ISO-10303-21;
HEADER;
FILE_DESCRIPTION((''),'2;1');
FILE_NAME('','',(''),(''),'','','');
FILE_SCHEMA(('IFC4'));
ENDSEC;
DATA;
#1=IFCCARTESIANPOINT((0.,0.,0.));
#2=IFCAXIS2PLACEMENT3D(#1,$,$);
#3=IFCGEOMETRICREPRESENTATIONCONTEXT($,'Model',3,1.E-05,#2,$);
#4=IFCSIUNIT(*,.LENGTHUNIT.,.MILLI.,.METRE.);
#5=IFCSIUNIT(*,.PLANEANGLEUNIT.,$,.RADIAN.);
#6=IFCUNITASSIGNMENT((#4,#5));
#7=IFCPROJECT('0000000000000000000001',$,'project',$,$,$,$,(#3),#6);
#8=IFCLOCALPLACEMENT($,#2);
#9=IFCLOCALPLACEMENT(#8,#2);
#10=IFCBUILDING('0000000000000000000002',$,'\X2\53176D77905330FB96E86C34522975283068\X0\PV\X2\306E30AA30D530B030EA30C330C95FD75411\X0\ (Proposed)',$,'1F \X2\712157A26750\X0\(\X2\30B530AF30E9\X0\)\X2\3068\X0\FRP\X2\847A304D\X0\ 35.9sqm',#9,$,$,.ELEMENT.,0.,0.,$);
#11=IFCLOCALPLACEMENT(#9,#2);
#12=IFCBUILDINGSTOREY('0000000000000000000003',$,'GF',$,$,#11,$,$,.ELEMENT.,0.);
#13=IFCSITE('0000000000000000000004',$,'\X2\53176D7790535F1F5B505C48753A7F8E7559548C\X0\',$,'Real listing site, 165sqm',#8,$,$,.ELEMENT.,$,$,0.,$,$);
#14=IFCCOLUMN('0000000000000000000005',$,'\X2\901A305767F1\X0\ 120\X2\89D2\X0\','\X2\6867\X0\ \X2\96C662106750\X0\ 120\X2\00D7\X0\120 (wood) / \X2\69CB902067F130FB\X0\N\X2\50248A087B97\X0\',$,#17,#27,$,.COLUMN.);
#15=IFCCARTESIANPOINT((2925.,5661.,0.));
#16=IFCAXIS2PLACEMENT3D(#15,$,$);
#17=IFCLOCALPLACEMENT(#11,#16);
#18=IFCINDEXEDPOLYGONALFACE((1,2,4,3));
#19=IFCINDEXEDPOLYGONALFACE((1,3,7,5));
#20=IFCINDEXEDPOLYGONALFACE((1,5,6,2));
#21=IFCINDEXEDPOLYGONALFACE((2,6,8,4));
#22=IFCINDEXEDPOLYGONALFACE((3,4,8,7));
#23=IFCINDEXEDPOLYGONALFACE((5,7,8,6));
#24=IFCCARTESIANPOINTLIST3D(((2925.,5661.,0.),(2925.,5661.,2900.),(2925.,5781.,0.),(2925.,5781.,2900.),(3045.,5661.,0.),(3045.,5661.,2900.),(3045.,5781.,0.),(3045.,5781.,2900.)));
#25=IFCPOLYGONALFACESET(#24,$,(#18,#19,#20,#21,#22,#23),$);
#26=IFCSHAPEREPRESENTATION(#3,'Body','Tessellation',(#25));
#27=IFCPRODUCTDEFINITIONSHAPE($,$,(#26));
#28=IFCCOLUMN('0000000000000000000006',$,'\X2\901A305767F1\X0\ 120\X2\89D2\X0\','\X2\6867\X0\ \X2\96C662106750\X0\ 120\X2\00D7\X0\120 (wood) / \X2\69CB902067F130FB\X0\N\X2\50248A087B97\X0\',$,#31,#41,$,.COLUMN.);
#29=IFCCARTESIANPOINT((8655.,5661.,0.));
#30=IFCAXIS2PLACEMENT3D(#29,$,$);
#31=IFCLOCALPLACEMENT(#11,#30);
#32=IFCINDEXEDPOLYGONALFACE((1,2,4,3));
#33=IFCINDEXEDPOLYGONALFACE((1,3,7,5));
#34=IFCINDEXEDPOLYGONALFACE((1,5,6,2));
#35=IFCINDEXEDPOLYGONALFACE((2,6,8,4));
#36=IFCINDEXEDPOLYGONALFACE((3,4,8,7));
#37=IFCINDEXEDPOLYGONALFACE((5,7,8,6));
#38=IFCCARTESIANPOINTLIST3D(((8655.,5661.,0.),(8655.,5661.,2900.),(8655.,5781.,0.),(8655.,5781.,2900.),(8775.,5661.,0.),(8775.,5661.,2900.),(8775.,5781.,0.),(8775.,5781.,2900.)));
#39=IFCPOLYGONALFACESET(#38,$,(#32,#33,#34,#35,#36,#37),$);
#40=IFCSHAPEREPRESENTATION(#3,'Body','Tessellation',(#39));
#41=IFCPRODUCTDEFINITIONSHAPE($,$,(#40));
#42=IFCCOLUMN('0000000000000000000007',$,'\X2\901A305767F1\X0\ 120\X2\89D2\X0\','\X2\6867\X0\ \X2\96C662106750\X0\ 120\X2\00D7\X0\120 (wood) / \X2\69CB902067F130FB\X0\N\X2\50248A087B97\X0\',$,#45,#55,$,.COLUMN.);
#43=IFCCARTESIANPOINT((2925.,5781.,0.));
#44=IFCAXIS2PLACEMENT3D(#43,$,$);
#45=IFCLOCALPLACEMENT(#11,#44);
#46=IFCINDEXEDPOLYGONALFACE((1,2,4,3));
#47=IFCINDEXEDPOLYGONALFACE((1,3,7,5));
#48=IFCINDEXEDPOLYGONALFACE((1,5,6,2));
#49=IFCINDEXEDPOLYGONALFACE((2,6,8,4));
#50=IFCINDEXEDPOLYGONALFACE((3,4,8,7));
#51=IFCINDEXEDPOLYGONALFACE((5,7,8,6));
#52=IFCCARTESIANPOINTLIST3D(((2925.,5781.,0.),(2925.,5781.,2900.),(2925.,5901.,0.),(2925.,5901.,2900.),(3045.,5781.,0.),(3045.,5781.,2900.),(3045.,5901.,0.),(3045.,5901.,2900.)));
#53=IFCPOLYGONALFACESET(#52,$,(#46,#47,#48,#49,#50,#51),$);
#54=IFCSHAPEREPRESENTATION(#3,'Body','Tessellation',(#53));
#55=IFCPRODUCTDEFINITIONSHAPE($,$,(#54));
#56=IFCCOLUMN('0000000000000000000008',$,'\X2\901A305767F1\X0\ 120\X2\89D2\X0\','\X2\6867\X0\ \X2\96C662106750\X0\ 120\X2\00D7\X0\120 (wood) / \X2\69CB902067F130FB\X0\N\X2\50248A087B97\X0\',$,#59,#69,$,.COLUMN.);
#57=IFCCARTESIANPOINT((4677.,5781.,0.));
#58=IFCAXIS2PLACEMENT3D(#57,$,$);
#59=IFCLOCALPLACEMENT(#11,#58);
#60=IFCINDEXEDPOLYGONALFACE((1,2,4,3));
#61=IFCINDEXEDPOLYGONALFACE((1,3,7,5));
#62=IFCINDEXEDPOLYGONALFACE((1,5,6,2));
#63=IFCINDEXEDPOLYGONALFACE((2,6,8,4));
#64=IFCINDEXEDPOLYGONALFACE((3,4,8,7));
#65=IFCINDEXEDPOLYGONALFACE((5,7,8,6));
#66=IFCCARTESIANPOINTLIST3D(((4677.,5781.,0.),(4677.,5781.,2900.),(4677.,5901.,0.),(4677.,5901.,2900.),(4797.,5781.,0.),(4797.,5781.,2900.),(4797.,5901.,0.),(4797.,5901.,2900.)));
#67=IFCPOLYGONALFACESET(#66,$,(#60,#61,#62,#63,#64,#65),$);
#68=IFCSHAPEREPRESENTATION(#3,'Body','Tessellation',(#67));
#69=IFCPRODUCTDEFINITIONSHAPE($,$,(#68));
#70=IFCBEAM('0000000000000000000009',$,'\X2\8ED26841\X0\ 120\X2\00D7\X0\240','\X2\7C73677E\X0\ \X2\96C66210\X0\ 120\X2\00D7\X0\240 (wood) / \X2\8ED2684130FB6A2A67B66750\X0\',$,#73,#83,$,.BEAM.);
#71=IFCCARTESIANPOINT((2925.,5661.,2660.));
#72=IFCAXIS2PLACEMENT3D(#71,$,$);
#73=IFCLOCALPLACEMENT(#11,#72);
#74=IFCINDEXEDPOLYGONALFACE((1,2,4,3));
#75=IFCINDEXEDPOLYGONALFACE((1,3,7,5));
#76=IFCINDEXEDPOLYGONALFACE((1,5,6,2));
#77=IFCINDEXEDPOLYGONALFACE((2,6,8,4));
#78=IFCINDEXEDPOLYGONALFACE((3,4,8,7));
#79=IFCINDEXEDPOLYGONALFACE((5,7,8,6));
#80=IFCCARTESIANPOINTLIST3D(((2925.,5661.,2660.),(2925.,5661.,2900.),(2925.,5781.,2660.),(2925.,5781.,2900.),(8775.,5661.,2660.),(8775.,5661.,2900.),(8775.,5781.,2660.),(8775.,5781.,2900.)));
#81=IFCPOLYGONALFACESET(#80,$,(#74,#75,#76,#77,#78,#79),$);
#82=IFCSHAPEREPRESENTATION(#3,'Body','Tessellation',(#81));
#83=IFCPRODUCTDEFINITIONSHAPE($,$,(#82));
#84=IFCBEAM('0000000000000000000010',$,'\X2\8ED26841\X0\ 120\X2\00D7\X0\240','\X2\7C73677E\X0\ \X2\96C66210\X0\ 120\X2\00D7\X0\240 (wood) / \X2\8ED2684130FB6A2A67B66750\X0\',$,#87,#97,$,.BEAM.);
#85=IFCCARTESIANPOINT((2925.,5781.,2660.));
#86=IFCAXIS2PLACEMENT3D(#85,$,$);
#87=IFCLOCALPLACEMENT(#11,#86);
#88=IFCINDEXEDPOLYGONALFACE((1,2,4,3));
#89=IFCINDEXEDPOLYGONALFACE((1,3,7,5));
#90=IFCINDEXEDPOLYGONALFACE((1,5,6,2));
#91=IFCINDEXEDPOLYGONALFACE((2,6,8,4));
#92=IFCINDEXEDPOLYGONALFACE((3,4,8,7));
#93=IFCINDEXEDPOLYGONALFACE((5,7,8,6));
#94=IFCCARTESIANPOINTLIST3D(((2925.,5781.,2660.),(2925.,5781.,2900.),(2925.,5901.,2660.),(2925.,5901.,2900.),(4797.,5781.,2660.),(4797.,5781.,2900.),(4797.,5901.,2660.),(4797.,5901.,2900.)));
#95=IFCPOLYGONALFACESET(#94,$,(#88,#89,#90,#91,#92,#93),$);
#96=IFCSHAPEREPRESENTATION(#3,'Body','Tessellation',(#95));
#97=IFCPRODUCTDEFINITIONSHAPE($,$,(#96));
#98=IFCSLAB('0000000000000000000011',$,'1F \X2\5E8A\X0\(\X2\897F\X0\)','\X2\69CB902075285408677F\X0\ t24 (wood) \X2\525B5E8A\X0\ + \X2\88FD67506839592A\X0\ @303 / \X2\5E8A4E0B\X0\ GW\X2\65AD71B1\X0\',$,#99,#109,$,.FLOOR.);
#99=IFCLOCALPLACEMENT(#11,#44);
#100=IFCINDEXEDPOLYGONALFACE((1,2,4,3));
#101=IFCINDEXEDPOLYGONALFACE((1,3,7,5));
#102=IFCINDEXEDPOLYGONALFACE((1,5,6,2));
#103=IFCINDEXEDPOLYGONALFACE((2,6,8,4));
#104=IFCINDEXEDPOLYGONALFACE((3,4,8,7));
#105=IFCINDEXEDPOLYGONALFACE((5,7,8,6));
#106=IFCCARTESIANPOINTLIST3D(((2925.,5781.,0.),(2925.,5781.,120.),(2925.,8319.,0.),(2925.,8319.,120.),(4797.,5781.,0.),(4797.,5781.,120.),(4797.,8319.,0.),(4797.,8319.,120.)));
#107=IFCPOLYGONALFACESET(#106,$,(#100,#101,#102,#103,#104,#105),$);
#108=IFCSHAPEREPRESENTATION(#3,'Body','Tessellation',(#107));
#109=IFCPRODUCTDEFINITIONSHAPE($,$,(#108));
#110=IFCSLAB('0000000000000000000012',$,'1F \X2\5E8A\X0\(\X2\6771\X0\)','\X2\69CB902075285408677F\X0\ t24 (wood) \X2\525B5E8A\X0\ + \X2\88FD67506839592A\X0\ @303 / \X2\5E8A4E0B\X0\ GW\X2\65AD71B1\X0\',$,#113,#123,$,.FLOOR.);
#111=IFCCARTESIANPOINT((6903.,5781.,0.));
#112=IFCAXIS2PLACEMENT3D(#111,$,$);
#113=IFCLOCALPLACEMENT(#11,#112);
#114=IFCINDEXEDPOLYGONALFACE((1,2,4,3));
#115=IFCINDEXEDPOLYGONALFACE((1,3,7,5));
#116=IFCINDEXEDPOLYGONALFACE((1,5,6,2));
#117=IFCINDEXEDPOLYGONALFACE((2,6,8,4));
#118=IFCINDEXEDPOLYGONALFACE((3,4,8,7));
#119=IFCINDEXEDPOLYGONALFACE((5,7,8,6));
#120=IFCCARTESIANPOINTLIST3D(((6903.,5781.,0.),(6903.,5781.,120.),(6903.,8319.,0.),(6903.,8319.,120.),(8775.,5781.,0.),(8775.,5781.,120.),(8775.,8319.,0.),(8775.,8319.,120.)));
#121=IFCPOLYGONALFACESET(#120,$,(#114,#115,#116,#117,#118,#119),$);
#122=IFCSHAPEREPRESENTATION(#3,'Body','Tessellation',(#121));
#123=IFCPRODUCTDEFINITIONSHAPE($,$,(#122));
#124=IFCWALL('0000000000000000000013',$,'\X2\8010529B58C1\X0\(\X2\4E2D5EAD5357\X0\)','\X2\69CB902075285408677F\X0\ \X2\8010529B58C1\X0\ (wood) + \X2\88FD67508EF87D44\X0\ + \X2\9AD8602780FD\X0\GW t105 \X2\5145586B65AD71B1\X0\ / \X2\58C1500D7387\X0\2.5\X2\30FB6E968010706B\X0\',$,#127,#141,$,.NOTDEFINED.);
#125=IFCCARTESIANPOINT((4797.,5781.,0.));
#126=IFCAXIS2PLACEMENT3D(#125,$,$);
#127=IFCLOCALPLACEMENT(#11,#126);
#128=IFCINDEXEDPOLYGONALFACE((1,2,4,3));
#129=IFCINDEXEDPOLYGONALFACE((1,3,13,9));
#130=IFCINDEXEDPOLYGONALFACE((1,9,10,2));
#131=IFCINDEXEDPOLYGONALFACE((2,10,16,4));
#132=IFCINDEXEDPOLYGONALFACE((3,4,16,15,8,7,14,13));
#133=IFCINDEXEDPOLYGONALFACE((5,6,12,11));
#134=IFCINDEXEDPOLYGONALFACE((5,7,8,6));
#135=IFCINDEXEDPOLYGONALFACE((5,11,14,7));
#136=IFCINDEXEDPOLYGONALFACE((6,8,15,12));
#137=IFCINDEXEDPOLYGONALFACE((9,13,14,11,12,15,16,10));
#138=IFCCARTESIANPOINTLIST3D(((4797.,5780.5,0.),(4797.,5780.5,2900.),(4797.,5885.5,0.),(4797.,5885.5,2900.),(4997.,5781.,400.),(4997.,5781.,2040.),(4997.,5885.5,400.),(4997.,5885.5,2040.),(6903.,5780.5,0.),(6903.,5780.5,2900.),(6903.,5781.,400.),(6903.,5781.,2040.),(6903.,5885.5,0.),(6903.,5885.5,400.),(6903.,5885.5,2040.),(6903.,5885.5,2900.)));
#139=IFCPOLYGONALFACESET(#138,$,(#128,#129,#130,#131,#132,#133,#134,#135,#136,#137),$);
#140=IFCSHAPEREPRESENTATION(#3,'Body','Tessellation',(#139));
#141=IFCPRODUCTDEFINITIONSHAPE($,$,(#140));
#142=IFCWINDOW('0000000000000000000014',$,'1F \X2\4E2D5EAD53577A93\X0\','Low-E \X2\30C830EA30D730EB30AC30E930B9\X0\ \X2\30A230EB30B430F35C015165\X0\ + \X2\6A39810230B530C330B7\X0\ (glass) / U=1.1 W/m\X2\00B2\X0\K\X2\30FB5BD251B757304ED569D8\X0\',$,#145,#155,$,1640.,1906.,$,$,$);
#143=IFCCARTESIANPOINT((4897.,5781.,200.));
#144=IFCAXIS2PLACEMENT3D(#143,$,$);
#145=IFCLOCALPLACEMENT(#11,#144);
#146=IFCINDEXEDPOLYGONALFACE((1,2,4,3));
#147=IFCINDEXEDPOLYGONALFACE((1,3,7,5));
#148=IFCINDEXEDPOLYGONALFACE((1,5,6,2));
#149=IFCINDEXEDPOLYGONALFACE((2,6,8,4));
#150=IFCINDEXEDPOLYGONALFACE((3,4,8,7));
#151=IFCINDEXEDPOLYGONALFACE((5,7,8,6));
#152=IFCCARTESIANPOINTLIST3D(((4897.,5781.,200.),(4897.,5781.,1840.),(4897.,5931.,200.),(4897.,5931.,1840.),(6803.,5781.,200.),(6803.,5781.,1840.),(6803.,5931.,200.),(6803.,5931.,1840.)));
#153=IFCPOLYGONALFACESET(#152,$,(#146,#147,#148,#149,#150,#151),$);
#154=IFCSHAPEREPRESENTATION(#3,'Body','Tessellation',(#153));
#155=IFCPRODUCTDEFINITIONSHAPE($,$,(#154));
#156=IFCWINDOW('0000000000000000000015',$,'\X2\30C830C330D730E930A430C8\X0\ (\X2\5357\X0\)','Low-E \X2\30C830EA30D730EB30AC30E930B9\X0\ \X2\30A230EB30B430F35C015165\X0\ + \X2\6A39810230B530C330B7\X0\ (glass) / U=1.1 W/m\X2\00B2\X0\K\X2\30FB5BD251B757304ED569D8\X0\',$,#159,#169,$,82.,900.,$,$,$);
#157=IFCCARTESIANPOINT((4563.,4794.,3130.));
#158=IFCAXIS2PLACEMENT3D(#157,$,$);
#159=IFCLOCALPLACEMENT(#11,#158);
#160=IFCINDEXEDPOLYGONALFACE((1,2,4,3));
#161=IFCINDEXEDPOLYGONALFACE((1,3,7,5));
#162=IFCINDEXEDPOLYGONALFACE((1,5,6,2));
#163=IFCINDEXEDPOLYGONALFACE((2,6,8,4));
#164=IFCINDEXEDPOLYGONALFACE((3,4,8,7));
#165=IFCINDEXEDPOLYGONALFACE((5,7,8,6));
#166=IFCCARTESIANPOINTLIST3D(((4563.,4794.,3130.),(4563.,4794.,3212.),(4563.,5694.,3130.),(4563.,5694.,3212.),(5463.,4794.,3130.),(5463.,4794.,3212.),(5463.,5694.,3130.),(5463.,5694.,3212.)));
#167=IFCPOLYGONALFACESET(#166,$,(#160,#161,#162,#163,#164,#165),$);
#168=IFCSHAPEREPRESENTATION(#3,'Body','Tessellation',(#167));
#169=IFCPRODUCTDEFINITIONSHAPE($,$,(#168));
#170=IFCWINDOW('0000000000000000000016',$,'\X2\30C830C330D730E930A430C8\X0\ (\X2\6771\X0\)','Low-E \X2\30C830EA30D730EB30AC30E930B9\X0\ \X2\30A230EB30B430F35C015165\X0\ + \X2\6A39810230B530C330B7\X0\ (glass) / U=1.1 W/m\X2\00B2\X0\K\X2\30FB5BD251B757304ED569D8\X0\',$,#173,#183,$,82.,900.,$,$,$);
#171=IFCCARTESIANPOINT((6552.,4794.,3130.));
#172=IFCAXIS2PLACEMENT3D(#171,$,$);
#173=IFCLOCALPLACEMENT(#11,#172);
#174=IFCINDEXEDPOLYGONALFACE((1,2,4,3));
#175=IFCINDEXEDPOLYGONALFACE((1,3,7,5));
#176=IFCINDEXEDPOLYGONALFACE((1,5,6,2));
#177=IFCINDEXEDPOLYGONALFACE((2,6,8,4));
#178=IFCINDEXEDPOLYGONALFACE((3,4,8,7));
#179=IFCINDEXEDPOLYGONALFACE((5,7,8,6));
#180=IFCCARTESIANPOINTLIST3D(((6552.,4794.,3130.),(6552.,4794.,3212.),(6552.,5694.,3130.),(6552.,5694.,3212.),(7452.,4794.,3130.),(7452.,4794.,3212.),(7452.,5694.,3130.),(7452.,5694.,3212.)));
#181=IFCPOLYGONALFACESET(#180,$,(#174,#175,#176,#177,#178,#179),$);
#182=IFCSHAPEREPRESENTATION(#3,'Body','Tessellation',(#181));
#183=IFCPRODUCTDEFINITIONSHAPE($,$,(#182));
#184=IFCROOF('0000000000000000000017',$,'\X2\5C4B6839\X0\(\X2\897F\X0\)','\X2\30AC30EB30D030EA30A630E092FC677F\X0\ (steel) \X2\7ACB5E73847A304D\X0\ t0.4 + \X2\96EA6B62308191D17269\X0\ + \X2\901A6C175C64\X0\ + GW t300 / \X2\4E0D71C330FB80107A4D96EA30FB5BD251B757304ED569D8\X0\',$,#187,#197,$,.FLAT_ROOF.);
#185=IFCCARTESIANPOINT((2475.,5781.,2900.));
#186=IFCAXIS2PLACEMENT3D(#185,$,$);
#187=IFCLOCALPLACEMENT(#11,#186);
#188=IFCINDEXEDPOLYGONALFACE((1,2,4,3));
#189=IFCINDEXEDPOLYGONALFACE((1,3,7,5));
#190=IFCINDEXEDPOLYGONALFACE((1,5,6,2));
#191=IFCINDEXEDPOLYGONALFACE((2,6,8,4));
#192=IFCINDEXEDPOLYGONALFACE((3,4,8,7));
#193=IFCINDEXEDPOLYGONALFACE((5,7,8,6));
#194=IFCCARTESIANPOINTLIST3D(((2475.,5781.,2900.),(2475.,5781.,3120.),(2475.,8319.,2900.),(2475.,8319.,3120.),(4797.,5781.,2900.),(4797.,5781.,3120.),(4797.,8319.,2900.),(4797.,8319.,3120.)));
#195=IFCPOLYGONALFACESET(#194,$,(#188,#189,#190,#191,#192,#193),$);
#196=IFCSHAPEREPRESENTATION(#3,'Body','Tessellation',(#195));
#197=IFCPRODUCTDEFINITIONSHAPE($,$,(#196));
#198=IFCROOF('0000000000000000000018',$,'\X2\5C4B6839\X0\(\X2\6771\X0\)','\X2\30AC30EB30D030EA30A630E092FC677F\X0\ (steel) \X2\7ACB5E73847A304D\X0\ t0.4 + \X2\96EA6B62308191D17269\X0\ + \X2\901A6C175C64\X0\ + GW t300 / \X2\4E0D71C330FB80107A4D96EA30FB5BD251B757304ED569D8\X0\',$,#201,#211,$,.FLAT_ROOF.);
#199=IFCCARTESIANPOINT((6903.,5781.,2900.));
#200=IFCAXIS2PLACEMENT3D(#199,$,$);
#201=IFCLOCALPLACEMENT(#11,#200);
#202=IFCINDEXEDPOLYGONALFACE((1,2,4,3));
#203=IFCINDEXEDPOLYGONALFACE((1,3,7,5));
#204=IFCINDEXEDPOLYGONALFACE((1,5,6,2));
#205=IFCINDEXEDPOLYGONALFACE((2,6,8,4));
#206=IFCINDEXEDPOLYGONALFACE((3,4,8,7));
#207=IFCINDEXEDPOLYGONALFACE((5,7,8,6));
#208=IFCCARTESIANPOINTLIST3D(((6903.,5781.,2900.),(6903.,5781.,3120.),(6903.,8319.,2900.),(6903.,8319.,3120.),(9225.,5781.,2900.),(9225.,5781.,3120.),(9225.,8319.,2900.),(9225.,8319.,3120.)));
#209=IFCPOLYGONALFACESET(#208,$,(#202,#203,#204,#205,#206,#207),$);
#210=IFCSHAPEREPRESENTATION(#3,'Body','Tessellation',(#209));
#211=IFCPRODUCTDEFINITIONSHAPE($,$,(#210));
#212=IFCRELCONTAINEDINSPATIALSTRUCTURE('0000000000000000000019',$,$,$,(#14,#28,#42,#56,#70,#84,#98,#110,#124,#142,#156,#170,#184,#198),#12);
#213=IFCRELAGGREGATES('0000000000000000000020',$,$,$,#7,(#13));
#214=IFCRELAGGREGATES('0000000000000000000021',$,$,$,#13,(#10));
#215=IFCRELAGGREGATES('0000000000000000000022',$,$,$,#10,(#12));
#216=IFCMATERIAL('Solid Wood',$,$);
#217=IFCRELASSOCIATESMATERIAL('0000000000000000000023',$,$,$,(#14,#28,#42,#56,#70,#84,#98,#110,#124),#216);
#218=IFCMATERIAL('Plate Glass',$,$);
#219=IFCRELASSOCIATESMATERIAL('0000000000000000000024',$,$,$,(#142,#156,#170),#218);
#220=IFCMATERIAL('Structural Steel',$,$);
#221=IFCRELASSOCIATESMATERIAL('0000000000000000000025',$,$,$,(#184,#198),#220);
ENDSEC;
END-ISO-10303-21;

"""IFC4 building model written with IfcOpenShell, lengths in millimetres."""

from ifc_helpers import new_model, si_unit, frame, frame_2d, origin, place, context, project, spatial, rectangle, extrude, material, element, fill, save


model = new_model("IFC4")

# Units and contexts
model_context = context("Model", 3, precision=1e-05, world=origin())
ifc_project = project(units=[si_unit("LENGTHUNIT", "METRE", prefix="MILLI"), si_unit("PLANEANGLEUNIT", "RADIAN")], contexts=[model_context])

# Site, building, storey
site_placement = place(None, origin())
site = spatial("IfcSite", under=ifc_project, at=site_placement, Name="北海道弟子屈町美留和", ObjectType="Real listing site, 165sqm", CompositionType="ELEMENT", RefElevation=0.0)
building_placement = place(site_placement, origin())
building = spatial("IfcBuilding", under=site, at=building_placement, Name="北海道・雨水利用とPVのオフグリッド志向 (Proposed)", ObjectType="1F 無垢材(サクラ)とFRP葺き 35.9sqm", CompositionType="ELEMENT", ElevationOfRefHeight=0.0, ElevationOfTerrain=0.0)
storey_placement = place(building_placement, origin())
storey = spatial("IfcBuildingStorey", under=building, at=storey_placement, Name="GF", CompositionType="ELEMENT", Elevation=0.0)

# Columns
ifc_material_1 = material(Name="Solid Wood")
column_1_placement = place(storey_placement, frame((2925.0, 5661.0, 0.0)))
element("IfcColumn", 1, at=column_1_placement, inside=storey, material=ifc_material_1, Name="通し柱 120角", Description="桧 集成材 120×120 (wood) / 構造柱・N値計算", PredefinedType="COLUMN", context=model_context, shape_type="SweptSolid", body=[
    extrude(rectangle(XDim=120.0, YDim=120.0, at=frame_2d((60.0, 60.0))), frame((2925.0, 5661.0, 0.0)), (0.0, 0.0, 1.0), 2900.0),
])
column_2_placement = place(storey_placement, frame((8655.0, 5661.0, 0.0)))
element("IfcColumn", 2, at=column_2_placement, inside=storey, material=ifc_material_1, Name="通し柱 120角", Description="桧 集成材 120×120 (wood) / 構造柱・N値計算", PredefinedType="COLUMN", context=model_context, shape_type="SweptSolid", body=[
    extrude(rectangle(XDim=120.0, YDim=120.0, at=frame_2d((60.0, 60.0))), frame((8655.0, 5661.0, 0.0)), (0.0, 0.0, 1.0), 2900.0),
])
column_3_placement = place(storey_placement, frame((2925.0, 5781.0, 0.0)))
element("IfcColumn", 3, at=column_3_placement, inside=storey, material=ifc_material_1, Name="通し柱 120角", Description="桧 集成材 120×120 (wood) / 構造柱・N値計算", PredefinedType="COLUMN", context=model_context, shape_type="SweptSolid", body=[
    extrude(rectangle(XDim=120.0, YDim=120.0, at=frame_2d((60.0, 60.0))), frame((2925.0, 5781.0, 0.0)), (0.0, 0.0, 1.0), 2900.0),
])
column_4_placement = place(storey_placement, frame((4677.0, 5781.0, 0.0)))
element("IfcColumn", 4, at=column_4_placement, inside=storey, material=ifc_material_1, Name="通し柱 120角", Description="桧 集成材 120×120 (wood) / 構造柱・N値計算", PredefinedType="COLUMN", context=model_context, shape_type="SweptSolid", body=[
    extrude(rectangle(XDim=120.0, YDim=120.0, at=frame_2d((60.0, 60.0))), frame((4677.0, 5781.0, 0.0)), (0.0, 0.0, 1.0), 2900.0),
])

# Beams
beam_1_placement = place(storey_placement, frame((2925.0, 5661.0, 2660.0)))
element("IfcBeam", 5, at=beam_1_placement, inside=storey, material=ifc_material_1, Name="軒桁 120×240", Description="米松 集成 120×240 (wood) / 軒桁・横架材", PredefinedType="BEAM", context=model_context, shape_type="SweptSolid", body=[
    extrude(rectangle(XDim=5850.0, YDim=120.0, at=frame_2d((2925.0, 60.0))), frame((2925.0, 5661.0, 2660.0)), (0.0, 0.0, 1.0), 240.0),
])
beam_2_placement = place(storey_placement, frame((2925.0, 5781.0, 2660.0)))
element("IfcBeam", 6, at=beam_2_placement, inside=storey, material=ifc_material_1, Name="軒桁 120×240", Description="米松 集成 120×240 (wood) / 軒桁・横架材", PredefinedType="BEAM", context=model_context, shape_type="SweptSolid", body=[
    extrude(rectangle(XDim=1872.0, YDim=120.0, at=frame_2d((936.0, 60.0))), frame((2925.0, 5781.0, 2660.0)), (0.0, 0.0, 1.0), 240.0),
])

# Slabs
slab_1_placement = place(storey_placement, frame((2925.0, 5781.0, 0.0)))
element("IfcSlab", 7, at=slab_1_placement, inside=storey, material=ifc_material_1, Name="1F 床(西)", Description="構造用合板 t24 (wood) 剛床 + 製材根太 @303 / 床下 GW断熱", PredefinedType="FLOOR", context=model_context, shape_type="SweptSolid", body=[
    extrude(rectangle(XDim=1872.0, YDim=2538.0, at=frame_2d((936.0, 1269.0))), frame((2925.0, 5781.0, 0.0)), (0.0, 0.0, 1.0), 120.0),
])
slab_2_placement = place(storey_placement, frame((6903.0, 5781.0, 0.0)))
element("IfcSlab", 8, at=slab_2_placement, inside=storey, material=ifc_material_1, Name="1F 床(東)", Description="構造用合板 t24 (wood) 剛床 + 製材根太 @303 / 床下 GW断熱", PredefinedType="FLOOR", context=model_context, shape_type="SweptSolid", body=[
    extrude(rectangle(XDim=1872.0, YDim=2538.0, at=frame_2d((936.0, 1269.0))), frame((6903.0, 5781.0, 0.0)), (0.0, 0.0, 1.0), 120.0),
])

# Wall, opening, window
wall_1_placement = place(storey_placement, frame((4797.0, 5781.0, 0.0)))
wall_1 = element("IfcWall", 9, at=wall_1_placement, inside=storey, material=ifc_material_1, Name="耐力壁(中庭南)", Description="構造用合板 耐力壁 (wood) + 製材軸組 + 高性能GW t105 充填断熱 / 壁倍率2.5・準耐火", PredefinedType="NOTDEFINED", context=model_context, shape_type="SweptSolid", body=[
    extrude(rectangle(XDim=2106.0, YDim=105.0, at=frame_2d((1053.0, 52.0))), frame((4797.0, 5781.0, 0.0)), (0.0, 0.0, 1.0), 2900.0),
])
opening_placement = place(storey_placement, frame((4897.0, 5781.0, 200.0)))
opening = element("IfcOpeningElement", 10, at=opening_placement, cuts=wall_1, PredefinedType="NOTDEFINED", context=model_context, shape_type="SweptSolid", body=[
    extrude(rectangle(XDim=1906.0, YDim=150.0, at=frame_2d((953.0, 75.0))), frame((4897.0, 5781.0, 200.0)), (0.0, 0.0, 1.0), 1640.0),
])
ifc_material_2 = material(Name="Plate Glass")
window_1_placement = place(storey_placement, frame((4897.0, 5781.0, 200.0)))
window_1 = element("IfcWindow", 11, at=window_1_placement, inside=storey, material=ifc_material_2, Name="1F 中庭南窓", Description="Low-E トリプルガラス アルゴン封入 + 樹脂サッシ (glass) / U=1.1 W/m²K・寒冷地仕様", OverallHeight=1640.0, OverallWidth=1906.0, context=model_context, shape_type="SweptSolid", body=[
    extrude(rectangle(XDim=1906.0, YDim=150.0, at=frame_2d((953.0, 75.0))), frame((4897.0, 5781.0, 200.0)), (0.0, 0.0, 1.0), 1640.0),
])
fill(opening, window_1)

# Windows
window_2_placement = place(storey_placement, frame((4563.0, 4794.0, 3130.0)))
element("IfcWindow", 12, at=window_2_placement, inside=storey, material=ifc_material_2, Name="トップライト (南)", Description="Low-E トリプルガラス アルゴン封入 + 樹脂サッシ (glass) / U=1.1 W/m²K・寒冷地仕様", OverallHeight=82.0, OverallWidth=900.0, context=model_context, shape_type="SweptSolid", body=[
    extrude(rectangle(XDim=900.0, YDim=900.0, at=frame_2d((450.0, 450.0))), frame((4563.0, 4794.0, 3130.0)), (0.0, 0.0, 1.0), 82.0),
])
window_3_placement = place(storey_placement, frame((6552.0, 4794.0, 3130.0)))
element("IfcWindow", 13, at=window_3_placement, inside=storey, material=ifc_material_2, Name="トップライト (東)", Description="Low-E トリプルガラス アルゴン封入 + 樹脂サッシ (glass) / U=1.1 W/m²K・寒冷地仕様", OverallHeight=82.0, OverallWidth=900.0, context=model_context, shape_type="SweptSolid", body=[
    extrude(rectangle(XDim=900.0, YDim=900.0, at=frame_2d((450.0, 450.0))), frame((6552.0, 4794.0, 3130.0)), (0.0, 0.0, 1.0), 82.0),
])

# Roofs
ifc_material_3 = material(Name="Structural Steel")
roof_1_placement = place(storey_placement, frame((2475.0, 5781.0, 2900.0)))
element("IfcRoof", 14, at=roof_1_placement, inside=storey, material=ifc_material_3, Name="屋根(西)", Description="ガルバリウム鋼板 (steel) 立平葺き t0.4 + 雪止め金物 + 通気層 + GW t300 / 不燃・耐積雪・寒冷地仕様", PredefinedType="FLAT_ROOF", context=model_context, shape_type="SweptSolid", body=[
    extrude(rectangle(XDim=2322.0, YDim=2538.0, at=frame_2d((1161.0, 1269.0))), frame((2475.0, 5781.0, 2900.0)), (0.0, 0.0, 1.0), 220.0),
])
roof_2_placement = place(storey_placement, frame((6903.0, 5781.0, 2900.0)))
element("IfcRoof", 15, at=roof_2_placement, inside=storey, material=ifc_material_3, Name="屋根(東)", Description="ガルバリウム鋼板 (steel) 立平葺き t0.4 + 雪止め金物 + 通気層 + GW t300 / 不燃・耐積雪・寒冷地仕様", PredefinedType="FLAT_ROOF", context=model_context, shape_type="SweptSolid", body=[
    extrude(rectangle(XDim=2322.0, YDim=2538.0, at=frame_2d((1161.0, 1269.0))), frame((6903.0, 5781.0, 2900.0)), (0.0, 0.0, 1.0), 220.0),
])

save(model, "model.ifc")
